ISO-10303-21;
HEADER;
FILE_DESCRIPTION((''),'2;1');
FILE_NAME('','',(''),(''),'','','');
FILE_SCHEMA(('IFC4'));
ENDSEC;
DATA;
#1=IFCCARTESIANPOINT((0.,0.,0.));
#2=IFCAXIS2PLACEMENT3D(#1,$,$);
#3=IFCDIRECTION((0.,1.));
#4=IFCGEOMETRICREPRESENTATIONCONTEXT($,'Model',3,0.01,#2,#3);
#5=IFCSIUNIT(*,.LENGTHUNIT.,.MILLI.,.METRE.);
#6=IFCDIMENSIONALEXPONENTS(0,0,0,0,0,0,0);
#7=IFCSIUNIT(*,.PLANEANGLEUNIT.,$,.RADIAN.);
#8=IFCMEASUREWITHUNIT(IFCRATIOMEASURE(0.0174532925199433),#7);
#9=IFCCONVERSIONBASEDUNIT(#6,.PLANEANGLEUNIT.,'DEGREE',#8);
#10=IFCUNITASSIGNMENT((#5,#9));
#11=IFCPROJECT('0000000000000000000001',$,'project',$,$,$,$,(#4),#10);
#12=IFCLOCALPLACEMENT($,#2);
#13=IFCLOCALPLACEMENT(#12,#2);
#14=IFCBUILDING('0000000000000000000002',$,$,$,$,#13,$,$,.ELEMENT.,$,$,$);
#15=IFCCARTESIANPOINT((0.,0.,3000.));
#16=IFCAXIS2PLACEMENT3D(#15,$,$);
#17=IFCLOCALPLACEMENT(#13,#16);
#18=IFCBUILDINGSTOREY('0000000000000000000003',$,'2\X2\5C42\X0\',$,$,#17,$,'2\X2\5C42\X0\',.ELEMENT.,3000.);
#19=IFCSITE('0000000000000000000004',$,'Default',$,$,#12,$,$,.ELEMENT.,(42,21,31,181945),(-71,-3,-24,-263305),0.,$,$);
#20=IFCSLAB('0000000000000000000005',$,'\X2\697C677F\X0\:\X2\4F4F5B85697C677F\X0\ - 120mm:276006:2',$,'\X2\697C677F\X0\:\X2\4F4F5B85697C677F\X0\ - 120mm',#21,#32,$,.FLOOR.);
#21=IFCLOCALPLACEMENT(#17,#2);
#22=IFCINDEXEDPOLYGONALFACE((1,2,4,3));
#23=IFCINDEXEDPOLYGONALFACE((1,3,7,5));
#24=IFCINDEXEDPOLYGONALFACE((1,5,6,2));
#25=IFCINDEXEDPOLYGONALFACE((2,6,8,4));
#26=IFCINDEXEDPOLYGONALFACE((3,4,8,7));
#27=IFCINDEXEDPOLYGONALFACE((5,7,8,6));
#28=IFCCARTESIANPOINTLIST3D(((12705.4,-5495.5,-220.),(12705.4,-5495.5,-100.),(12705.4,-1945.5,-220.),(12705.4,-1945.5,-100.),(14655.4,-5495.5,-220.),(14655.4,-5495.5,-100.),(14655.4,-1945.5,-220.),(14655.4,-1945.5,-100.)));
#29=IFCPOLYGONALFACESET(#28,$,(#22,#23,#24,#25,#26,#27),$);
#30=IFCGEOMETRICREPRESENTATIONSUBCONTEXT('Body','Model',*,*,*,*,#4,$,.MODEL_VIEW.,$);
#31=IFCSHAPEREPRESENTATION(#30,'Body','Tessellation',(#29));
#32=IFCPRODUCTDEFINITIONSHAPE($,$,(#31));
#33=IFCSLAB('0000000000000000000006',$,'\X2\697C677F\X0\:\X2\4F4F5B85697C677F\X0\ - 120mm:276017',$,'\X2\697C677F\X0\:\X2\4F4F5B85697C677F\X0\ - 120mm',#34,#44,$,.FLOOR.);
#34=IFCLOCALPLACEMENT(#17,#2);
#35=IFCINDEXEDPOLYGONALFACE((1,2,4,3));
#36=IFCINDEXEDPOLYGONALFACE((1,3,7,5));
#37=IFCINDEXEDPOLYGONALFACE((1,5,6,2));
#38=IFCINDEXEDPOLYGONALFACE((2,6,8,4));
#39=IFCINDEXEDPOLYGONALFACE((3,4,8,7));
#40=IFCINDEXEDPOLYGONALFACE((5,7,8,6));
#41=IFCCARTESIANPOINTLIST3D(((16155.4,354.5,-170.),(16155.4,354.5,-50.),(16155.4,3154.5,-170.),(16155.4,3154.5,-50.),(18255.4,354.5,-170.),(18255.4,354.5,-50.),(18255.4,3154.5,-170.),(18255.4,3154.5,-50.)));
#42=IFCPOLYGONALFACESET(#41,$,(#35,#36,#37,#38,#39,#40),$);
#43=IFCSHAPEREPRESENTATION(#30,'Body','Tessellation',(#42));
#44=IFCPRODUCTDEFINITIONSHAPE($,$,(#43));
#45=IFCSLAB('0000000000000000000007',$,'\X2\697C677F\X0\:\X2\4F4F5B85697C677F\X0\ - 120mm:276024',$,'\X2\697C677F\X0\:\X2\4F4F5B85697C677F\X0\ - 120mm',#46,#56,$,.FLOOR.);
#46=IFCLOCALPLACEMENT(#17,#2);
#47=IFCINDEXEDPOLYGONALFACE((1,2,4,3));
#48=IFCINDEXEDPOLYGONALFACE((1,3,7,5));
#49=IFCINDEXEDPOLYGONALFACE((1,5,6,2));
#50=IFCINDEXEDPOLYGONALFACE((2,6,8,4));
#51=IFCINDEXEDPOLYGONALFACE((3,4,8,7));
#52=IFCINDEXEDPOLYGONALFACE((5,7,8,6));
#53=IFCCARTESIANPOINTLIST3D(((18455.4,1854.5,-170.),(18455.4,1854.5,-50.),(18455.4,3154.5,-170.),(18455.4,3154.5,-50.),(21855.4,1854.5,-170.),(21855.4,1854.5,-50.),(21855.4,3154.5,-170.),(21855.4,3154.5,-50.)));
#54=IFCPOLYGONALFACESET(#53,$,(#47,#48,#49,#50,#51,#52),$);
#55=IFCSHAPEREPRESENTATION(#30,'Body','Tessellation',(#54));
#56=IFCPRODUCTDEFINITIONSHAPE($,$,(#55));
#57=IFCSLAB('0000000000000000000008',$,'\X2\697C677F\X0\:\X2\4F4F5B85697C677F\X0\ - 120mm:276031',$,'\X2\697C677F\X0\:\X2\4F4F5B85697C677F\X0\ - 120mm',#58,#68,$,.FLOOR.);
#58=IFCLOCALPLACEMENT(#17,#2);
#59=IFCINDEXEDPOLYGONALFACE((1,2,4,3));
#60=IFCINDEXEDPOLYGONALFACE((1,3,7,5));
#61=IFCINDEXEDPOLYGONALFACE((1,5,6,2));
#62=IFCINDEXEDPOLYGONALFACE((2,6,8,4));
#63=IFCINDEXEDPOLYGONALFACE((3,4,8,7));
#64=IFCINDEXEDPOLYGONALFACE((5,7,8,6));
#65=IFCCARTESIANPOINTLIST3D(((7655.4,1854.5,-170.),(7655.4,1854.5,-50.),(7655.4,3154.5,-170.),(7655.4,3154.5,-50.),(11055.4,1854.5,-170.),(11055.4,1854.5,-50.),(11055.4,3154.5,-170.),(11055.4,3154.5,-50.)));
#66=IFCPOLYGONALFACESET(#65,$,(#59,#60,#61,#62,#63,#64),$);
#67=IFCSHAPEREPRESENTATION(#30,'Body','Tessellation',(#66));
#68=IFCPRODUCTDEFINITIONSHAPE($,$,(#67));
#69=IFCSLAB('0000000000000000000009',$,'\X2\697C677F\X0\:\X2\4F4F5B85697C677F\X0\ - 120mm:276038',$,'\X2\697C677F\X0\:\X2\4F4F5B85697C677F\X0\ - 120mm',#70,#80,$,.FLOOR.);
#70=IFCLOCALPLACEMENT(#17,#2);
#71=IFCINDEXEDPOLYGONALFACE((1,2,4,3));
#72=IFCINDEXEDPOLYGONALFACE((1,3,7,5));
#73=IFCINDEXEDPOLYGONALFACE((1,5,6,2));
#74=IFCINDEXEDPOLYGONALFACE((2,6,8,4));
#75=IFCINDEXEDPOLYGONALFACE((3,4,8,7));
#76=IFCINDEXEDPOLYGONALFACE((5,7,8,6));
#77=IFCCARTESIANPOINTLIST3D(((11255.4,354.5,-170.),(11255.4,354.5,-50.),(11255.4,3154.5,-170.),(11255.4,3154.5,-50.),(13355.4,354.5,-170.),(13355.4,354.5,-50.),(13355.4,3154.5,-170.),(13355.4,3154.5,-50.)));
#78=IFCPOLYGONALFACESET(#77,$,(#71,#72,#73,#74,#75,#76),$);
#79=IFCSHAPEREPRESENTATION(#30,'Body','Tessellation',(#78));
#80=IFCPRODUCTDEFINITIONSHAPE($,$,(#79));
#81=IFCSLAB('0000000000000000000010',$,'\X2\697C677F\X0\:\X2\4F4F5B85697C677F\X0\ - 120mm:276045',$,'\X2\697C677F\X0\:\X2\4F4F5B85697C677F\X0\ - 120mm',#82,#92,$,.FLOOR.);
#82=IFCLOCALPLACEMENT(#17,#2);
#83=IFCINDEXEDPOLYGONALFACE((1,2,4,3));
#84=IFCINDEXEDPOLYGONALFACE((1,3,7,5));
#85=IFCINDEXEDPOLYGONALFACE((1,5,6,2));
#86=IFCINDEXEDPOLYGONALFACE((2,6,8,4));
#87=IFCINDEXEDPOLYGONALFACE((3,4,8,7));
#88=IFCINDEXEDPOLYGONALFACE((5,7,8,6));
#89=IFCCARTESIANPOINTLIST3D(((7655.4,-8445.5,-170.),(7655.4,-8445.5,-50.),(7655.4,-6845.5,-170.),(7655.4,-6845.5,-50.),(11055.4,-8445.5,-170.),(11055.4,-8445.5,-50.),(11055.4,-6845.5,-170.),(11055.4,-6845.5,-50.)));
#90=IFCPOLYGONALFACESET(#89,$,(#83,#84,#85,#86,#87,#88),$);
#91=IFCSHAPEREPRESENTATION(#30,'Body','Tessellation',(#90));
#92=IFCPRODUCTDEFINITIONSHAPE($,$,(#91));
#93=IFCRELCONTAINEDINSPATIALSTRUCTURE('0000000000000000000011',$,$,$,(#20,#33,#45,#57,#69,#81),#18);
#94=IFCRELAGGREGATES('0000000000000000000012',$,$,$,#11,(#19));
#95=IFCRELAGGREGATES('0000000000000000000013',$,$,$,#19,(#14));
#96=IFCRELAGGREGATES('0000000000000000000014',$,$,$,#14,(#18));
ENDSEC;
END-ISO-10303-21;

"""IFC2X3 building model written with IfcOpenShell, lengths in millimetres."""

from ifc_helpers import new_model, entity, si_unit, converted_unit, direction, frame, frame_2d, origin, origin_2d_with_axis, place, context, subcontext, project, spatial, rectangle, extrude, element, save


model = new_model("IFC2X3")

# Units and contexts
model_context = context("Model", 3, precision=0.01, world=origin(), true_north=direction((0.0, 1.0)))
body_context = subcontext(model_context, "Body", "Model", "MODEL_VIEW")
ifc_project = project(units=[si_unit("LENGTHUNIT", "METRE", prefix="MILLI"), converted_unit("PLANEANGLEUNIT", "DEGREE", entity("IfcRatioMeasure", 0.0174532925199433), si_unit("PLANEANGLEUNIT", "RADIAN"), dimensions=[0, 0, 0, 0, 0, 0, 0])], contexts=[model_context])

# Site, building, storey
site_placement = place(None, origin())
site = spatial("IfcSite", under=ifc_project, at=site_placement, Name="Default", CompositionType="ELEMENT", RefLatitude=(42, 21, 31, 181945), RefLongitude=(-71, -3, -24, -263305), RefElevation=0.0)
building_placement = place(site_placement, origin())
building = spatial("IfcBuilding", under=site, at=building_placement, CompositionType="ELEMENT")
storey_placement = place(building_placement, frame((0.0, 0.0, 3000.0)))
storey = spatial("IfcBuildingStorey", under=building, at=storey_placement, Name="2层", LongName="2层", CompositionType="ELEMENT", Elevation=3000.0)

# Slabs
slab_1_placement = place(storey_placement, frame((12705.4, -5495.5, -220.0)))
element("IfcSlab", 1, at=slab_1_placement, inside=storey, Name="楼板:住宅楼板 - 120mm:276006:2", ObjectType="楼板:住宅楼板 - 120mm", PredefinedType="FLOOR", context=body_context, shape_type="SweptSolid", body=[
    extrude(rectangle(XDim=1950.0, YDim=3550.0, at=frame_2d((1075.0, 0.0), x_axis=(-1.0, 0.0))), frame((2050.0, 1775.0, 120.0), z_axis=(0.0, 0.0, -1.0), x_axis=(-1.0, 0.0, 0.0)), (0.0, 0.0, 1.0), 120.0),
])
slab_2_placement = place(storey_placement, origin())
element("IfcSlab", 2, at=slab_2_placement, inside=storey, Name="楼板:住宅楼板 - 120mm:276017", ObjectType="楼板:住宅楼板 - 120mm", PredefinedType="FLOOR", context=body_context, shape_type="SweptSolid", body=[
    extrude(rectangle(XDim=2800.0, YDim=2100.0, at=frame_2d((0.0, 0.0), x_axis=(1.0, 0.0))), frame((17205.4, 1754.5, -50.0), z_axis=(0.0, 0.0, -1.0), x_axis=(0.0, 1.0, 0.0)), (0.0, 0.0, 1.0), 120.0),
])
slab_3_placement = place(storey_placement, origin())
element("IfcSlab", 3, at=slab_3_placement, inside=storey, Name="楼板:住宅楼板 - 120mm:276024", ObjectType="楼板:住宅楼板 - 120mm", PredefinedType="FLOOR", context=body_context, shape_type="SweptSolid", body=[
    extrude(rectangle(XDim=1300.0, YDim=3400.0, at=frame_2d((0.0, 0.0), x_axis=(1.0, 0.0))), frame((20155.4, 2504.5, -50.0), z_axis=(0.0, 0.0, -1.0), x_axis=(0.0, 1.0, 0.0)), (0.0, 0.0, 1.0), 120.0),
])
slab_4_placement = place(storey_placement, origin())
element("IfcSlab", 4, at=slab_4_placement, inside=storey, Name="楼板:住宅楼板 - 120mm:276031", ObjectType="楼板:住宅楼板 - 120mm", PredefinedType="FLOOR", context=body_context, shape_type="SweptSolid", body=[
    extrude(rectangle(XDim=1300.0, YDim=3400.0, at=frame_2d((0.0, 0.0), x_axis=(1.0, 0.0))), frame((9355.4, 2504.5, -50.0), z_axis=(0.0, 0.0, -1.0), x_axis=(0.0, 1.0, 0.0)), (0.0, 0.0, 1.0), 120.0),
])
slab_5_placement = place(storey_placement, origin())
element("IfcSlab", 5, at=slab_5_placement, inside=storey, Name="楼板:住宅楼板 - 120mm:276038", ObjectType="楼板:住宅楼板 - 120mm", PredefinedType="FLOOR", context=body_context, shape_type="SweptSolid", body=[
    extrude(rectangle(XDim=2800.0, YDim=2100.0, at=origin_2d_with_axis()), frame((12305.4, 1754.5, -50.0), z_axis=(0.0, 0.0, -1.0), x_axis=(0.0, 1.0, 0.0)), (0.0, 0.0, 1.0), 120.0),
])
slab_6_placement = place(storey_placement, origin())
element("IfcSlab", 6, at=slab_6_placement, inside=storey, Name="楼板:住宅楼板 - 120mm:276045", ObjectType="楼板:住宅楼板 - 120mm", PredefinedType="FLOOR", context=body_context, shape_type="SweptSolid", body=[
    extrude(rectangle(XDim=1600.0, YDim=3400.0, at=frame_2d((0.0, 0.0), x_axis=(1.0, 0.0))), frame((9355.4, -7645.5, -50.0), z_axis=(0.0, 0.0, -1.0), x_axis=(0.0, 1.0, 0.0)), (0.0, 0.0, 1.0), 120.0),
])

save(model, "model.ifc")
